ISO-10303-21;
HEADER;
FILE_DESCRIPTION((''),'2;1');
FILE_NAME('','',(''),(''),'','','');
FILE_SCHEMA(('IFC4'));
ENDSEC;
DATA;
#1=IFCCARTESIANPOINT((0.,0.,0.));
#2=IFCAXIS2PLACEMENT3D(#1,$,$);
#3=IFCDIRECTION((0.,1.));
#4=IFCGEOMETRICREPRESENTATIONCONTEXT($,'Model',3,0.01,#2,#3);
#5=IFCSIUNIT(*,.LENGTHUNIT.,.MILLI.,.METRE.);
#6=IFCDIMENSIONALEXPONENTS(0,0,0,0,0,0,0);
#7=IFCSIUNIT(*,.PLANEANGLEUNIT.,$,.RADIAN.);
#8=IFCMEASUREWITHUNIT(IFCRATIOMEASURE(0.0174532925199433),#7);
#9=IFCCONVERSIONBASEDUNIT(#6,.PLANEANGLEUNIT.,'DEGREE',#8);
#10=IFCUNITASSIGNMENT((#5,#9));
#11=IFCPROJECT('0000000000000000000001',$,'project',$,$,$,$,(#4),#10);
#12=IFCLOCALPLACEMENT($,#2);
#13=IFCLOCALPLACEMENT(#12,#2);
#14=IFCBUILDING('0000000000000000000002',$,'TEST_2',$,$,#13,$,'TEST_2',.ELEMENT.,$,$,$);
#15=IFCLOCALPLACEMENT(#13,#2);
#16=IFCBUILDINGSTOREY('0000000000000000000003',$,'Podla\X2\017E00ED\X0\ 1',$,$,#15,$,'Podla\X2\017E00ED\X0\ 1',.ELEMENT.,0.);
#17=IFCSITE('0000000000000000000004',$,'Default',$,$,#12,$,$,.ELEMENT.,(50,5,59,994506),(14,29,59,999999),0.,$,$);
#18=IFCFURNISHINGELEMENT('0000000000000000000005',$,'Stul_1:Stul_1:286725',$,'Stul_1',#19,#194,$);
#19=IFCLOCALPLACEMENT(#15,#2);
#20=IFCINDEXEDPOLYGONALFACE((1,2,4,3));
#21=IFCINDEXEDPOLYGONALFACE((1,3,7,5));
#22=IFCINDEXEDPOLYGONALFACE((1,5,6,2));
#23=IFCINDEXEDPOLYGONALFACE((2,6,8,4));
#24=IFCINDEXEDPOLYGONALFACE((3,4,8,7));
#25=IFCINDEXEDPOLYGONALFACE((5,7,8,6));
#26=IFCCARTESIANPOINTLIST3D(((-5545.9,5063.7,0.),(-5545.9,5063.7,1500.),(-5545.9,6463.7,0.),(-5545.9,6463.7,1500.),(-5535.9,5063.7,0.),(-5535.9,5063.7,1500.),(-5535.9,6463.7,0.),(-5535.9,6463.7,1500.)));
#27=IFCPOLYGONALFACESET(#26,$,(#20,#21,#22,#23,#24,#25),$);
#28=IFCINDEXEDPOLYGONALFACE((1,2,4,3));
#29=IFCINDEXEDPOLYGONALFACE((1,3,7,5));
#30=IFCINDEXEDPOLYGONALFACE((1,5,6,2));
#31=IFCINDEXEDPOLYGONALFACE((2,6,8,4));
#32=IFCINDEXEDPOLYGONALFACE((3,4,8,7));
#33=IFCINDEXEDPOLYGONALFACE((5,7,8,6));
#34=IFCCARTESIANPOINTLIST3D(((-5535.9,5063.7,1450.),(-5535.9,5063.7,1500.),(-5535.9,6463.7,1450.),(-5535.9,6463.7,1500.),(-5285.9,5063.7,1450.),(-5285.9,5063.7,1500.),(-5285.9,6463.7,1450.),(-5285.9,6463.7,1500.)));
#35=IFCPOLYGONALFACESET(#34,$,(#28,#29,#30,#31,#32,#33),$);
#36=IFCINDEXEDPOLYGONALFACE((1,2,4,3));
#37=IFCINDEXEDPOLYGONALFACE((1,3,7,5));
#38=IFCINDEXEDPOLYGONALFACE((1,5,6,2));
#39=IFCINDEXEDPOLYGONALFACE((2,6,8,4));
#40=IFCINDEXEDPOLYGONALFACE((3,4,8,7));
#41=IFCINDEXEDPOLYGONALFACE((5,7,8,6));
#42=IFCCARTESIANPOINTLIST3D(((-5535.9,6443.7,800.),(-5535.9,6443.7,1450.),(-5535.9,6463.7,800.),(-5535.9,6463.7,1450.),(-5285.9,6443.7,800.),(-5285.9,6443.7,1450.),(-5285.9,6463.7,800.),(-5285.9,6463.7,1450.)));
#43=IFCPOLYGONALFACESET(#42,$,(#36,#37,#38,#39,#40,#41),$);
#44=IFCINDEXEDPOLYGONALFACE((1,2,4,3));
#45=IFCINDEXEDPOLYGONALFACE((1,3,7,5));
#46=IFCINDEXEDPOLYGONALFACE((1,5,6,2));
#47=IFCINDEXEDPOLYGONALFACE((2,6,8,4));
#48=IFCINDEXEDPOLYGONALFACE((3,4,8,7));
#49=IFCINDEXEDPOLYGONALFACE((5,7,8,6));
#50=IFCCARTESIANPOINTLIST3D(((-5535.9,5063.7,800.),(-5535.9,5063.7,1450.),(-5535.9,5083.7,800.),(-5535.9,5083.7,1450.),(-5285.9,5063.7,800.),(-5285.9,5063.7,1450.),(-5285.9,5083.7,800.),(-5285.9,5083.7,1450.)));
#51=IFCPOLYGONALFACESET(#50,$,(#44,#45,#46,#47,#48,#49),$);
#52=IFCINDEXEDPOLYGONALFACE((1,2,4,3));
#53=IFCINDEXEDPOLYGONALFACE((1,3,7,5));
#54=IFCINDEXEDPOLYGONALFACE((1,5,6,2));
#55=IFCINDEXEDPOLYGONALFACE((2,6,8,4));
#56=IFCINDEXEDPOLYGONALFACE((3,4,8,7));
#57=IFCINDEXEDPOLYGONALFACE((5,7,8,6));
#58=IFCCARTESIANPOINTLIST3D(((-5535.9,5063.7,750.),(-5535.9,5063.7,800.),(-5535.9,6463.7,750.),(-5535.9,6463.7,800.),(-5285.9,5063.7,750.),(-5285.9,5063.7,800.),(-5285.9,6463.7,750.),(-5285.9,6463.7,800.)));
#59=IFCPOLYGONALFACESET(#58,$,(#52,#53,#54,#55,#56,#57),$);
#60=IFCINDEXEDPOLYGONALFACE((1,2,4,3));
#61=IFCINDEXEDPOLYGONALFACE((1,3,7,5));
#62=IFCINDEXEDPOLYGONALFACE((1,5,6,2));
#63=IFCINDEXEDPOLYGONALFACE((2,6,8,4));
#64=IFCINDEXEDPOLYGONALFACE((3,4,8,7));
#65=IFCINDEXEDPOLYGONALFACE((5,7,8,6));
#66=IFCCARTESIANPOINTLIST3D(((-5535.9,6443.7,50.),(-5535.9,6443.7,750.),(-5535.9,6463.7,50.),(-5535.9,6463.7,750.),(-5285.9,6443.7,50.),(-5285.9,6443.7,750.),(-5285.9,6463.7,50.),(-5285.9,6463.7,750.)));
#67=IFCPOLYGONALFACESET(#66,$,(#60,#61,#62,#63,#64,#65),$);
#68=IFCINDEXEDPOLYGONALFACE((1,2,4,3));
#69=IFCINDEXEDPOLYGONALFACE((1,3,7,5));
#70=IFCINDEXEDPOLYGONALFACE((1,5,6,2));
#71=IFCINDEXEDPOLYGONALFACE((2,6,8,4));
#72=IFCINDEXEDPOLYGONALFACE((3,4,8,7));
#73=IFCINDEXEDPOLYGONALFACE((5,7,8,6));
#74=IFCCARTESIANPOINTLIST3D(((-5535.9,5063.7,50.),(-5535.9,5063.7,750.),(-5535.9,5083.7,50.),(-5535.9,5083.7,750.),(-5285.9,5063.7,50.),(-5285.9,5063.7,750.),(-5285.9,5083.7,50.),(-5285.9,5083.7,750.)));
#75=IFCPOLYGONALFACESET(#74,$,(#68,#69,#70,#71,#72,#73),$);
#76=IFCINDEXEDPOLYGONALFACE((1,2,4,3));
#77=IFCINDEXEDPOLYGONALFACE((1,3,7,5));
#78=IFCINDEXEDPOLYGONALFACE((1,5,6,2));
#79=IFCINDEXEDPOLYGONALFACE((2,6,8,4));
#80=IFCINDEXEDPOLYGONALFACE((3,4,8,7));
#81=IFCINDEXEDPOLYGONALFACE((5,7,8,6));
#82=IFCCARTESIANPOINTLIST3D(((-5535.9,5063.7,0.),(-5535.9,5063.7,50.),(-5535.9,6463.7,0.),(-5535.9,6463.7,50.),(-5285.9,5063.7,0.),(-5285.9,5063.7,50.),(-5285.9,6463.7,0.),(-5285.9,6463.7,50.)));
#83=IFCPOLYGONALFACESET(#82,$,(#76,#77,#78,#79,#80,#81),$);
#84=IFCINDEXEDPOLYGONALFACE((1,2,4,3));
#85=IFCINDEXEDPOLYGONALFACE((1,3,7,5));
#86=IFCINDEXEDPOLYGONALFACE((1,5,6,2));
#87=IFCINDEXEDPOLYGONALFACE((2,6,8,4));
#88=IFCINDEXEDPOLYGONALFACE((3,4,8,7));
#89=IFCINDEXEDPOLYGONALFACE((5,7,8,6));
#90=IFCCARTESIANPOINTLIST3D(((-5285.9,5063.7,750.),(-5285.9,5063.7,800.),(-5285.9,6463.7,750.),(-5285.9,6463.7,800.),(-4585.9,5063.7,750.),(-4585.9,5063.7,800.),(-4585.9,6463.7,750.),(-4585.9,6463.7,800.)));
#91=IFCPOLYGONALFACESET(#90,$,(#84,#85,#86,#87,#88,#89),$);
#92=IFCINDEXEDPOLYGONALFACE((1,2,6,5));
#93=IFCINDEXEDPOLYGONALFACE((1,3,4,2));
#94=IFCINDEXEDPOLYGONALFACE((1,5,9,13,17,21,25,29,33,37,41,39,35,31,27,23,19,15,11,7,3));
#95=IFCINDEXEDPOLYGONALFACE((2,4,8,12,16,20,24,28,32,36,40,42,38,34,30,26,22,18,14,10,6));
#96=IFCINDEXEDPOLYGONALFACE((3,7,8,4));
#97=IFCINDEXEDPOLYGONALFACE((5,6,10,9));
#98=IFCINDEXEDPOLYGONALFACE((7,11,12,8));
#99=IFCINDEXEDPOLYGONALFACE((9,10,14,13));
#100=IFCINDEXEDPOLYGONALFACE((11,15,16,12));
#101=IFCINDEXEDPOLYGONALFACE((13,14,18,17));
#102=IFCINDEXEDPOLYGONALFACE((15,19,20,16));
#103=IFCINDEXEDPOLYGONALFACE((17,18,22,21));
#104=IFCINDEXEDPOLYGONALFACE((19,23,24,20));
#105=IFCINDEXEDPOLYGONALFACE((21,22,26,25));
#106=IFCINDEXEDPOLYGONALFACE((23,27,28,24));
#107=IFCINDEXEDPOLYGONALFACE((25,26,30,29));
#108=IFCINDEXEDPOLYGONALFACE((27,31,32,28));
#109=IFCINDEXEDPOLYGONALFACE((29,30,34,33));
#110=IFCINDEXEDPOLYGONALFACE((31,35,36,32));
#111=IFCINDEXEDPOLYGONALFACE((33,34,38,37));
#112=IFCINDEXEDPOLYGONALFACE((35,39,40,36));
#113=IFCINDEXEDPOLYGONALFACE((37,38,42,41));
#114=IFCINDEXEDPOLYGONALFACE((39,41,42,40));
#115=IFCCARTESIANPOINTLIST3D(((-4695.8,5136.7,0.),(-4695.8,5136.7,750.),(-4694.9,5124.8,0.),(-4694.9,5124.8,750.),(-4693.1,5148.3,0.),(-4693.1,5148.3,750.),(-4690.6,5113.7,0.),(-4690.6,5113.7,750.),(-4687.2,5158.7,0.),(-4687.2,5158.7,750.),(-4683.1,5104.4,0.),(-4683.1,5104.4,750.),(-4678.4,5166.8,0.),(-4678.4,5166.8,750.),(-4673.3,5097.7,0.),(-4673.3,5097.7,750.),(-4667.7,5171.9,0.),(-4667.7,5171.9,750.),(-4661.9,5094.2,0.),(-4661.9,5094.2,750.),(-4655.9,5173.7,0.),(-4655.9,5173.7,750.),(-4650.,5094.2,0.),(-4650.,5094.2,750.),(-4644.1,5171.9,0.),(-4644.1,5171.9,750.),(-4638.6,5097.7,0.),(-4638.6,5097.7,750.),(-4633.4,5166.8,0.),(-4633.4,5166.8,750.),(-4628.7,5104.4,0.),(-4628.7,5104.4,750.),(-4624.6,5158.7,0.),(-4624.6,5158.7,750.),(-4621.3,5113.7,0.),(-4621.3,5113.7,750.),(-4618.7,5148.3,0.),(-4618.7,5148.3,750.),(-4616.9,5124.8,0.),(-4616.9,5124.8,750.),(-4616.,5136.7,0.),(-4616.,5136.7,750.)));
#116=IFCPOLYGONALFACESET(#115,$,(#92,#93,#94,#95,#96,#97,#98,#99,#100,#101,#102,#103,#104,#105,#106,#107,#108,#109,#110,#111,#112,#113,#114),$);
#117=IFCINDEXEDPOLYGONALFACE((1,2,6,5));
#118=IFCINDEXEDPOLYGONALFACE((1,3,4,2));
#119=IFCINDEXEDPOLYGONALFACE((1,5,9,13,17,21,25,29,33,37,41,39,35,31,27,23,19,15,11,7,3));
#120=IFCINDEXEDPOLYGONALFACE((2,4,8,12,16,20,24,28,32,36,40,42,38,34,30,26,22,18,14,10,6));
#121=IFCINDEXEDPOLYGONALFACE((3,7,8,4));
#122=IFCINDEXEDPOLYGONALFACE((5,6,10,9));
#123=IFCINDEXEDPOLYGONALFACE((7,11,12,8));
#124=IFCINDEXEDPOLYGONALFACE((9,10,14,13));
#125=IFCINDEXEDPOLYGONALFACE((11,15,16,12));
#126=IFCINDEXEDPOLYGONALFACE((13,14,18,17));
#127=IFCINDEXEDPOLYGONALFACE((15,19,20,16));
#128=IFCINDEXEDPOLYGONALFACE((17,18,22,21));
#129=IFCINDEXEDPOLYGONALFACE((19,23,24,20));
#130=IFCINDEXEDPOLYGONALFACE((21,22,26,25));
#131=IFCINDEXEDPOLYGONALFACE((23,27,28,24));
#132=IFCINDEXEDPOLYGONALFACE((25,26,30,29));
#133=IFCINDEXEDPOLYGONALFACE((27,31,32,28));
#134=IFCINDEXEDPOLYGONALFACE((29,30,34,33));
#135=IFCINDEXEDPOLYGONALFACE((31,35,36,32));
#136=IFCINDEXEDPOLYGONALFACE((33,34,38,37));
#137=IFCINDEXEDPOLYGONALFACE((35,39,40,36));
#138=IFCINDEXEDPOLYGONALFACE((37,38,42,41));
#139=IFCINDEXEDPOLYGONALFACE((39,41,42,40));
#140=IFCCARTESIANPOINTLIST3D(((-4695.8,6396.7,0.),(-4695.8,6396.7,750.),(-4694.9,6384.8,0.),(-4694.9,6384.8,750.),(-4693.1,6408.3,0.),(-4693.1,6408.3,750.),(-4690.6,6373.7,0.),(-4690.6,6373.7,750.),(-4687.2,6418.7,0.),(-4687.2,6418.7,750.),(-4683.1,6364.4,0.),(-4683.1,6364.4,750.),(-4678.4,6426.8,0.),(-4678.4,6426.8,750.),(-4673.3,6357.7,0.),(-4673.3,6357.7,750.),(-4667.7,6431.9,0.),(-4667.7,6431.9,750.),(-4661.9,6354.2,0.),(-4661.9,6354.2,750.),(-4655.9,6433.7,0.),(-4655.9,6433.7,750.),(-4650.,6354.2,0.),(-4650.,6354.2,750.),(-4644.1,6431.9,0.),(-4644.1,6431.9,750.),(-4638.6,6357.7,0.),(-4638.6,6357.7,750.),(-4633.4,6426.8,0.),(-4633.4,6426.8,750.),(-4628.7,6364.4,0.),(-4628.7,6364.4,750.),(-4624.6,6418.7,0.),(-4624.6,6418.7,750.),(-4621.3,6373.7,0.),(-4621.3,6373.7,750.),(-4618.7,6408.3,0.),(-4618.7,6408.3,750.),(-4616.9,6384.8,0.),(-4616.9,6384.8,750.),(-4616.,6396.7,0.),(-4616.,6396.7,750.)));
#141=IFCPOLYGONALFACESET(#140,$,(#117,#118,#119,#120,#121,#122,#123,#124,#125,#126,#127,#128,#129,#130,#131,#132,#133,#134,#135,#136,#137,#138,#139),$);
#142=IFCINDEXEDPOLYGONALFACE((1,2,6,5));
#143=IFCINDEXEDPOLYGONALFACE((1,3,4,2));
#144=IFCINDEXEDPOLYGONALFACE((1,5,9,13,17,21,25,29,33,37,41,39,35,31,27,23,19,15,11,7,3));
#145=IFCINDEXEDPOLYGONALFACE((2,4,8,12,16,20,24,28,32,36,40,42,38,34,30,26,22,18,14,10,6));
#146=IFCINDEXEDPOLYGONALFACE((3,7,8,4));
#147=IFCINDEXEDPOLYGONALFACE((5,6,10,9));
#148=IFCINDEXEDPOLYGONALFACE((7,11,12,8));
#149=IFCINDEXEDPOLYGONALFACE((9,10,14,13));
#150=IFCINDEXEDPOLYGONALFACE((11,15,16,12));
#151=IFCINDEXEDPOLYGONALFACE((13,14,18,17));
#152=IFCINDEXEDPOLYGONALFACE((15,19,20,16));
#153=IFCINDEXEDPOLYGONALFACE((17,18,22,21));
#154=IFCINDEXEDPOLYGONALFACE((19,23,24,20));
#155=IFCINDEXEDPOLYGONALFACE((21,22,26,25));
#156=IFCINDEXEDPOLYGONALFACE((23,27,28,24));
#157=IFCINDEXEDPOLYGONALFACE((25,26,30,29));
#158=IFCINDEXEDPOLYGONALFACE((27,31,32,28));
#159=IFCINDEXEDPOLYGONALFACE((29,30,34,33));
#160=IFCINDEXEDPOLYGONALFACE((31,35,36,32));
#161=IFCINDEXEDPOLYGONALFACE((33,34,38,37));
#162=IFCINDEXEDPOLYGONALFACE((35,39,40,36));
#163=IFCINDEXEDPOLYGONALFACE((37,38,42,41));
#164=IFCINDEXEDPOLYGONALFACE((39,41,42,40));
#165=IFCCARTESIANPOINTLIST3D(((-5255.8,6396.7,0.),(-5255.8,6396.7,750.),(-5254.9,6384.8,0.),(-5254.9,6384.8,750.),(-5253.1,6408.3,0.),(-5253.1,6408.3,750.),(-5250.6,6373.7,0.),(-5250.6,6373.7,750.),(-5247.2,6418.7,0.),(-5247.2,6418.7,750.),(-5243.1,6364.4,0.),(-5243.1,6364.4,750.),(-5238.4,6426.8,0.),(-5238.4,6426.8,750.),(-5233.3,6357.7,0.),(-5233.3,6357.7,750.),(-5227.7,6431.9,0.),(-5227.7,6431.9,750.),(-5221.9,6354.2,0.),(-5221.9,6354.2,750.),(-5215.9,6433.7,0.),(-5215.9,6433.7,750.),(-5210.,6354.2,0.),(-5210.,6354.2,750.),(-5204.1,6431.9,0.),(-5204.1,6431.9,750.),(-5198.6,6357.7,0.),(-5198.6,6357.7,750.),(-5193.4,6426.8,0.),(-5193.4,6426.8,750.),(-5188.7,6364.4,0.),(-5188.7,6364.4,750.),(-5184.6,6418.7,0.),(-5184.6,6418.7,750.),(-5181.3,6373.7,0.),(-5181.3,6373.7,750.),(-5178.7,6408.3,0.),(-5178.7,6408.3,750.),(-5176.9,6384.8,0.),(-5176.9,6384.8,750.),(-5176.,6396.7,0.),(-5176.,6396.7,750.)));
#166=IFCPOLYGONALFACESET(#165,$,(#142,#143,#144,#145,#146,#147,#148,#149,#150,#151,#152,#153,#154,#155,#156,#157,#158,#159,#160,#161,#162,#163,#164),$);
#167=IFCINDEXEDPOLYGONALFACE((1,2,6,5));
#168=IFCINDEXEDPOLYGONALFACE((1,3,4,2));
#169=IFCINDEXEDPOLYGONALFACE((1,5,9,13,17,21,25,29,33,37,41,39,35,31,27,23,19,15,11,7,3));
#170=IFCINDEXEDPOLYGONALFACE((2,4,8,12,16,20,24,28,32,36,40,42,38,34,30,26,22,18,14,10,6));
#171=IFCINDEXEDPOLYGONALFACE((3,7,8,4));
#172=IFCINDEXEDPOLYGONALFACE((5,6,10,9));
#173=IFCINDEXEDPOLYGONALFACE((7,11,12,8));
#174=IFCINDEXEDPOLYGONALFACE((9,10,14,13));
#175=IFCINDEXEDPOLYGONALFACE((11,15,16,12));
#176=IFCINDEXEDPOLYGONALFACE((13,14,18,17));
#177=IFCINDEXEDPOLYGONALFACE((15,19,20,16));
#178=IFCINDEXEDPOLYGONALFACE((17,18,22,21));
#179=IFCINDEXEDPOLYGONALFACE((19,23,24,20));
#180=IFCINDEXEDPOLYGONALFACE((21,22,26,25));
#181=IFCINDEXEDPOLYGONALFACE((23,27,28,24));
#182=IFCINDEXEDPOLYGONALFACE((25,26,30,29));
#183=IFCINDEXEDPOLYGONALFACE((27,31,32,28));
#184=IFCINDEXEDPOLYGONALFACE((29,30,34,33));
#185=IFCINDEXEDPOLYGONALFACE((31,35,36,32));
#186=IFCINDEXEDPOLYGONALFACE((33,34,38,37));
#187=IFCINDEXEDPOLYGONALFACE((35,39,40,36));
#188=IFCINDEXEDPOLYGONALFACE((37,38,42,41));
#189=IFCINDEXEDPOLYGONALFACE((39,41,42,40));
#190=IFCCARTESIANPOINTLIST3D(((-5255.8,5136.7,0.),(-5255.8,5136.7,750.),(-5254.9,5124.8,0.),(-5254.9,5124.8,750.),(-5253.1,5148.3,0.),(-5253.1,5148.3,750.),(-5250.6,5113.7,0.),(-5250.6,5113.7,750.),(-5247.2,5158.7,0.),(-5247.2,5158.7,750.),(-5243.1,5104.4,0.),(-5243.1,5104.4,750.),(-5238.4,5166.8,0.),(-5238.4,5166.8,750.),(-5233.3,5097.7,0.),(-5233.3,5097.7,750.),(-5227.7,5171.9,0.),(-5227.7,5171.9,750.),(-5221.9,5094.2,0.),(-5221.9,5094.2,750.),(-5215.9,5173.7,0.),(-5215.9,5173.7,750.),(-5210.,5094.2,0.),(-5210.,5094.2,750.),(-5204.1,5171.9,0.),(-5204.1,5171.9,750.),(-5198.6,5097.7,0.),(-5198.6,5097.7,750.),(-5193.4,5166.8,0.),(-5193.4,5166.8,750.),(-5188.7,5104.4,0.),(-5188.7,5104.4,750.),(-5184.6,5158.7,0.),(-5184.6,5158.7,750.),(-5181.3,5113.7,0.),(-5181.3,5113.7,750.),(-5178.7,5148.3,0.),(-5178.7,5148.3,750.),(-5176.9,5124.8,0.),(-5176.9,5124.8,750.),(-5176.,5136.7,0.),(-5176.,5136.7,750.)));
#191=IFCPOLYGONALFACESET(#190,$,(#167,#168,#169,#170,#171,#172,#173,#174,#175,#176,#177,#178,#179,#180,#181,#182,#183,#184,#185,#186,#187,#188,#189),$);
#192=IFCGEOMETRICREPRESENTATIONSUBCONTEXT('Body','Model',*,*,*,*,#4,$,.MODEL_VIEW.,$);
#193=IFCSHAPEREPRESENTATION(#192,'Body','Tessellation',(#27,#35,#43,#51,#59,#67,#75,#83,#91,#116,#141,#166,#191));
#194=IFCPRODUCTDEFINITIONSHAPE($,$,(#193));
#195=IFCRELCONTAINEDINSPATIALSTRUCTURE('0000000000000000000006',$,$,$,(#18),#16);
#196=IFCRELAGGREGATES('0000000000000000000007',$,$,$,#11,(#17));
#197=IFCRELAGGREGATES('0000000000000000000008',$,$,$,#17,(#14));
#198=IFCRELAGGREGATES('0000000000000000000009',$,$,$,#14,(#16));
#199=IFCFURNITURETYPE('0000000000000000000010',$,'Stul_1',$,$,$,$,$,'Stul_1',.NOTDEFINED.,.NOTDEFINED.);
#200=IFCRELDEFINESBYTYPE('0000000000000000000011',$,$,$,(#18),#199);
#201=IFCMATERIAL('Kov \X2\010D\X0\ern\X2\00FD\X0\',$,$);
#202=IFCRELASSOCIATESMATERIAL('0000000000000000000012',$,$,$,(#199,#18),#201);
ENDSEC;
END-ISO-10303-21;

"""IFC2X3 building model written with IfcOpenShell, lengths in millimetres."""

from ifc_helpers import new_model, entity, si_unit, converted_unit, direction, frame, frame_2d, origin, origin_2d_with_axis, place, context, subcontext, project, spatial, rectangle, circle, extrude, source, transform, mapped, material, type_object, type_shapes, element, save


model = new_model("IFC2X3")

# Units and contexts
model_context = context("Model", 3, precision=0.01, world=origin(), true_north=direction((0.0, 1.0)))
body_context = subcontext(model_context, "Body", "Model", "MODEL_VIEW")
ifc_project = project(units=[si_unit("LENGTHUNIT", "METRE", prefix="MILLI"), converted_unit("PLANEANGLEUNIT", "DEGREE", entity("IfcRatioMeasure", 0.0174532925199433), si_unit("PLANEANGLEUNIT", "RADIAN"), dimensions=[0, 0, 0, 0, 0, 0, 0])], contexts=[model_context])

# Site, building, storey
site_placement = place(None, origin())
site = spatial("IfcSite", under=ifc_project, at=site_placement, Name="Default", CompositionType="ELEMENT", RefLatitude=(50, 5, 59, 994506), RefLongitude=(14, 29, 59, 999999), RefElevation=0.0)
building_placement = place(site_placement, origin())
building = spatial("IfcBuilding", under=site, at=building_placement, Name="TEST_2", LongName="TEST_2", CompositionType="ELEMENT")
storey_placement = place(building_placement, origin())
storey = spatial("IfcBuildingStorey", under=building, at=storey_placement, Name="Podlaží 1", LongName="Podlaží 1", CompositionType="ELEMENT", Elevation=0.0)

# Furnishing element
ifc_material_1 = material(Name="Kov černý")
furniture_type = type_object("IfcFurnitureType", Name="Stul_1", ElementType="Stul_1", material=ifc_material_1)
shared_shape_1 = source(origin(), body_context, "Body", "SweptSolid", [
    extrude(rectangle(XDim=1400.0, YDim=10.0, at=origin_2d_with_axis()), frame((0.0, 605.0, 0.0), z_axis=(0.0, 0.0, 1.0), x_axis=(-1.0, 0.0, 0.0)), (0.0, 0.0, 1.0), 1500.0),
    extrude(rectangle(XDim=1400.0, YDim=250.0, at=frame_2d((0.0, 0.0), x_axis=(1.0, 0.0))), frame((0.0, 475.0, 1450.0), z_axis=(0.0, 0.0, 1.0), x_axis=(-1.0, 0.0, 0.0)), (0.0, 0.0, 1.0), 50.0),
    extrude(rectangle(XDim=20.0, YDim=250.0, at=origin_2d_with_axis()), frame((690.0, 475.0, 800.0), z_axis=(0.0, 0.0, 1.0), x_axis=(-1.0, 0.0, 0.0)), (0.0, 0.0, 1.0), 650.0),
    extrude(rectangle(XDim=20.0, YDim=250.0, at=frame_2d((0.0, 0.0), x_axis=(1.0, 0.0))), frame((-690.0, 475.0, 800.0), z_axis=(0.0, 0.0, 1.0), x_axis=(-1.0, 0.0, 0.0)), (0.0, 0.0, 1.0), 650.0),
    extrude(rectangle(XDim=1400.0, YDim=250.0, at=origin_2d_with_axis()), frame((0.0, 475.0, 750.0), z_axis=(0.0, 0.0, 1.0), x_axis=(-1.0, 0.0, 0.0)), (0.0, 0.0, 1.0), 50.0),
    extrude(rectangle(XDim=20.0, YDim=250.0, at=origin_2d_with_axis()), frame((690.0, 475.0, 50.0), z_axis=(0.0, 0.0, 1.0), x_axis=(-1.0, 0.0, 0.0)), (0.0, 0.0, 1.0), 700.0),
    extrude(rectangle(XDim=20.0, YDim=250.0, at=frame_2d((0.0, 0.0), x_axis=(1.0, 0.0))), frame((-690.0, 475.0, 50.0), z_axis=(0.0, 0.0, 1.0), x_axis=(-1.0, 0.0, 0.0)), (0.0, 0.0, 1.0), 700.0),
    extrude(rectangle(XDim=1400.0, YDim=250.0, at=origin_2d_with_axis()), frame((0.0, 475.0, 0.0), z_axis=(0.0, 0.0, 1.0), x_axis=(-1.0, 0.0, 0.0)), (0.0, 0.0, 1.0), 50.0),
    extrude(rectangle(XDim=1400.0, YDim=700.0, at=origin_2d_with_axis()), frame((0.0, 0.0, 750.0), z_axis=(0.0, 0.0, 1.0), x_axis=(-1.0, 0.0, 0.0)), (0.0, 0.0, 1.0), 50.0),
    extrude(circle(Radius=40.0, at=frame_2d((0.0, 0.0), x_axis=(1.0, 0.0))), frame((-630.0, -280.0, 0.0)), (0.0, 0.0, 1.0), 750.0),
    extrude(circle(Radius=40.0, at=frame_2d((0.0, 0.0), x_axis=(1.0, 0.0))), frame((630.0, -280.0, 0.0)), (0.0, 0.0, 1.0), 750.0),
    extrude(circle(Radius=40.0, at=frame_2d((0.0, 0.0), x_axis=(1.0, 0.0))), frame((630.0, 280.0, 0.0)), (0.0, 0.0, 1.0), 750.0),
    extrude(circle(Radius=40.0, at=frame_2d((0.0, 0.0), x_axis=(1.0, 0.0))), frame((-630.0, 280.0, 0.0)), (0.0, 0.0, 1.0), 750.0),
])
type_shapes(furniture_type, [shared_shape_1])
for number, where, z_axis, x_axis, name in (
    (1, (-4935.9, 5763.7, 0.0), (0.0, 0.0, 1.0), (0.0, 1.0, 0.0), "Stul_1:Stul_1:286725"),
):
    element("IfcFurnishingElement", number, at=place(storey_placement, frame(where, z_axis=z_axis, x_axis=x_axis)), inside=storey, type_object=furniture_type, material=ifc_material_1, Name=name, ObjectType="Stul_1", context=body_context, shape_type="MappedRepresentation", body=[
        mapped(shared_shape_1, transform((0.0, 0.0, 0.0), scale=1.0)),
    ])

save(model, "model.ifc")
